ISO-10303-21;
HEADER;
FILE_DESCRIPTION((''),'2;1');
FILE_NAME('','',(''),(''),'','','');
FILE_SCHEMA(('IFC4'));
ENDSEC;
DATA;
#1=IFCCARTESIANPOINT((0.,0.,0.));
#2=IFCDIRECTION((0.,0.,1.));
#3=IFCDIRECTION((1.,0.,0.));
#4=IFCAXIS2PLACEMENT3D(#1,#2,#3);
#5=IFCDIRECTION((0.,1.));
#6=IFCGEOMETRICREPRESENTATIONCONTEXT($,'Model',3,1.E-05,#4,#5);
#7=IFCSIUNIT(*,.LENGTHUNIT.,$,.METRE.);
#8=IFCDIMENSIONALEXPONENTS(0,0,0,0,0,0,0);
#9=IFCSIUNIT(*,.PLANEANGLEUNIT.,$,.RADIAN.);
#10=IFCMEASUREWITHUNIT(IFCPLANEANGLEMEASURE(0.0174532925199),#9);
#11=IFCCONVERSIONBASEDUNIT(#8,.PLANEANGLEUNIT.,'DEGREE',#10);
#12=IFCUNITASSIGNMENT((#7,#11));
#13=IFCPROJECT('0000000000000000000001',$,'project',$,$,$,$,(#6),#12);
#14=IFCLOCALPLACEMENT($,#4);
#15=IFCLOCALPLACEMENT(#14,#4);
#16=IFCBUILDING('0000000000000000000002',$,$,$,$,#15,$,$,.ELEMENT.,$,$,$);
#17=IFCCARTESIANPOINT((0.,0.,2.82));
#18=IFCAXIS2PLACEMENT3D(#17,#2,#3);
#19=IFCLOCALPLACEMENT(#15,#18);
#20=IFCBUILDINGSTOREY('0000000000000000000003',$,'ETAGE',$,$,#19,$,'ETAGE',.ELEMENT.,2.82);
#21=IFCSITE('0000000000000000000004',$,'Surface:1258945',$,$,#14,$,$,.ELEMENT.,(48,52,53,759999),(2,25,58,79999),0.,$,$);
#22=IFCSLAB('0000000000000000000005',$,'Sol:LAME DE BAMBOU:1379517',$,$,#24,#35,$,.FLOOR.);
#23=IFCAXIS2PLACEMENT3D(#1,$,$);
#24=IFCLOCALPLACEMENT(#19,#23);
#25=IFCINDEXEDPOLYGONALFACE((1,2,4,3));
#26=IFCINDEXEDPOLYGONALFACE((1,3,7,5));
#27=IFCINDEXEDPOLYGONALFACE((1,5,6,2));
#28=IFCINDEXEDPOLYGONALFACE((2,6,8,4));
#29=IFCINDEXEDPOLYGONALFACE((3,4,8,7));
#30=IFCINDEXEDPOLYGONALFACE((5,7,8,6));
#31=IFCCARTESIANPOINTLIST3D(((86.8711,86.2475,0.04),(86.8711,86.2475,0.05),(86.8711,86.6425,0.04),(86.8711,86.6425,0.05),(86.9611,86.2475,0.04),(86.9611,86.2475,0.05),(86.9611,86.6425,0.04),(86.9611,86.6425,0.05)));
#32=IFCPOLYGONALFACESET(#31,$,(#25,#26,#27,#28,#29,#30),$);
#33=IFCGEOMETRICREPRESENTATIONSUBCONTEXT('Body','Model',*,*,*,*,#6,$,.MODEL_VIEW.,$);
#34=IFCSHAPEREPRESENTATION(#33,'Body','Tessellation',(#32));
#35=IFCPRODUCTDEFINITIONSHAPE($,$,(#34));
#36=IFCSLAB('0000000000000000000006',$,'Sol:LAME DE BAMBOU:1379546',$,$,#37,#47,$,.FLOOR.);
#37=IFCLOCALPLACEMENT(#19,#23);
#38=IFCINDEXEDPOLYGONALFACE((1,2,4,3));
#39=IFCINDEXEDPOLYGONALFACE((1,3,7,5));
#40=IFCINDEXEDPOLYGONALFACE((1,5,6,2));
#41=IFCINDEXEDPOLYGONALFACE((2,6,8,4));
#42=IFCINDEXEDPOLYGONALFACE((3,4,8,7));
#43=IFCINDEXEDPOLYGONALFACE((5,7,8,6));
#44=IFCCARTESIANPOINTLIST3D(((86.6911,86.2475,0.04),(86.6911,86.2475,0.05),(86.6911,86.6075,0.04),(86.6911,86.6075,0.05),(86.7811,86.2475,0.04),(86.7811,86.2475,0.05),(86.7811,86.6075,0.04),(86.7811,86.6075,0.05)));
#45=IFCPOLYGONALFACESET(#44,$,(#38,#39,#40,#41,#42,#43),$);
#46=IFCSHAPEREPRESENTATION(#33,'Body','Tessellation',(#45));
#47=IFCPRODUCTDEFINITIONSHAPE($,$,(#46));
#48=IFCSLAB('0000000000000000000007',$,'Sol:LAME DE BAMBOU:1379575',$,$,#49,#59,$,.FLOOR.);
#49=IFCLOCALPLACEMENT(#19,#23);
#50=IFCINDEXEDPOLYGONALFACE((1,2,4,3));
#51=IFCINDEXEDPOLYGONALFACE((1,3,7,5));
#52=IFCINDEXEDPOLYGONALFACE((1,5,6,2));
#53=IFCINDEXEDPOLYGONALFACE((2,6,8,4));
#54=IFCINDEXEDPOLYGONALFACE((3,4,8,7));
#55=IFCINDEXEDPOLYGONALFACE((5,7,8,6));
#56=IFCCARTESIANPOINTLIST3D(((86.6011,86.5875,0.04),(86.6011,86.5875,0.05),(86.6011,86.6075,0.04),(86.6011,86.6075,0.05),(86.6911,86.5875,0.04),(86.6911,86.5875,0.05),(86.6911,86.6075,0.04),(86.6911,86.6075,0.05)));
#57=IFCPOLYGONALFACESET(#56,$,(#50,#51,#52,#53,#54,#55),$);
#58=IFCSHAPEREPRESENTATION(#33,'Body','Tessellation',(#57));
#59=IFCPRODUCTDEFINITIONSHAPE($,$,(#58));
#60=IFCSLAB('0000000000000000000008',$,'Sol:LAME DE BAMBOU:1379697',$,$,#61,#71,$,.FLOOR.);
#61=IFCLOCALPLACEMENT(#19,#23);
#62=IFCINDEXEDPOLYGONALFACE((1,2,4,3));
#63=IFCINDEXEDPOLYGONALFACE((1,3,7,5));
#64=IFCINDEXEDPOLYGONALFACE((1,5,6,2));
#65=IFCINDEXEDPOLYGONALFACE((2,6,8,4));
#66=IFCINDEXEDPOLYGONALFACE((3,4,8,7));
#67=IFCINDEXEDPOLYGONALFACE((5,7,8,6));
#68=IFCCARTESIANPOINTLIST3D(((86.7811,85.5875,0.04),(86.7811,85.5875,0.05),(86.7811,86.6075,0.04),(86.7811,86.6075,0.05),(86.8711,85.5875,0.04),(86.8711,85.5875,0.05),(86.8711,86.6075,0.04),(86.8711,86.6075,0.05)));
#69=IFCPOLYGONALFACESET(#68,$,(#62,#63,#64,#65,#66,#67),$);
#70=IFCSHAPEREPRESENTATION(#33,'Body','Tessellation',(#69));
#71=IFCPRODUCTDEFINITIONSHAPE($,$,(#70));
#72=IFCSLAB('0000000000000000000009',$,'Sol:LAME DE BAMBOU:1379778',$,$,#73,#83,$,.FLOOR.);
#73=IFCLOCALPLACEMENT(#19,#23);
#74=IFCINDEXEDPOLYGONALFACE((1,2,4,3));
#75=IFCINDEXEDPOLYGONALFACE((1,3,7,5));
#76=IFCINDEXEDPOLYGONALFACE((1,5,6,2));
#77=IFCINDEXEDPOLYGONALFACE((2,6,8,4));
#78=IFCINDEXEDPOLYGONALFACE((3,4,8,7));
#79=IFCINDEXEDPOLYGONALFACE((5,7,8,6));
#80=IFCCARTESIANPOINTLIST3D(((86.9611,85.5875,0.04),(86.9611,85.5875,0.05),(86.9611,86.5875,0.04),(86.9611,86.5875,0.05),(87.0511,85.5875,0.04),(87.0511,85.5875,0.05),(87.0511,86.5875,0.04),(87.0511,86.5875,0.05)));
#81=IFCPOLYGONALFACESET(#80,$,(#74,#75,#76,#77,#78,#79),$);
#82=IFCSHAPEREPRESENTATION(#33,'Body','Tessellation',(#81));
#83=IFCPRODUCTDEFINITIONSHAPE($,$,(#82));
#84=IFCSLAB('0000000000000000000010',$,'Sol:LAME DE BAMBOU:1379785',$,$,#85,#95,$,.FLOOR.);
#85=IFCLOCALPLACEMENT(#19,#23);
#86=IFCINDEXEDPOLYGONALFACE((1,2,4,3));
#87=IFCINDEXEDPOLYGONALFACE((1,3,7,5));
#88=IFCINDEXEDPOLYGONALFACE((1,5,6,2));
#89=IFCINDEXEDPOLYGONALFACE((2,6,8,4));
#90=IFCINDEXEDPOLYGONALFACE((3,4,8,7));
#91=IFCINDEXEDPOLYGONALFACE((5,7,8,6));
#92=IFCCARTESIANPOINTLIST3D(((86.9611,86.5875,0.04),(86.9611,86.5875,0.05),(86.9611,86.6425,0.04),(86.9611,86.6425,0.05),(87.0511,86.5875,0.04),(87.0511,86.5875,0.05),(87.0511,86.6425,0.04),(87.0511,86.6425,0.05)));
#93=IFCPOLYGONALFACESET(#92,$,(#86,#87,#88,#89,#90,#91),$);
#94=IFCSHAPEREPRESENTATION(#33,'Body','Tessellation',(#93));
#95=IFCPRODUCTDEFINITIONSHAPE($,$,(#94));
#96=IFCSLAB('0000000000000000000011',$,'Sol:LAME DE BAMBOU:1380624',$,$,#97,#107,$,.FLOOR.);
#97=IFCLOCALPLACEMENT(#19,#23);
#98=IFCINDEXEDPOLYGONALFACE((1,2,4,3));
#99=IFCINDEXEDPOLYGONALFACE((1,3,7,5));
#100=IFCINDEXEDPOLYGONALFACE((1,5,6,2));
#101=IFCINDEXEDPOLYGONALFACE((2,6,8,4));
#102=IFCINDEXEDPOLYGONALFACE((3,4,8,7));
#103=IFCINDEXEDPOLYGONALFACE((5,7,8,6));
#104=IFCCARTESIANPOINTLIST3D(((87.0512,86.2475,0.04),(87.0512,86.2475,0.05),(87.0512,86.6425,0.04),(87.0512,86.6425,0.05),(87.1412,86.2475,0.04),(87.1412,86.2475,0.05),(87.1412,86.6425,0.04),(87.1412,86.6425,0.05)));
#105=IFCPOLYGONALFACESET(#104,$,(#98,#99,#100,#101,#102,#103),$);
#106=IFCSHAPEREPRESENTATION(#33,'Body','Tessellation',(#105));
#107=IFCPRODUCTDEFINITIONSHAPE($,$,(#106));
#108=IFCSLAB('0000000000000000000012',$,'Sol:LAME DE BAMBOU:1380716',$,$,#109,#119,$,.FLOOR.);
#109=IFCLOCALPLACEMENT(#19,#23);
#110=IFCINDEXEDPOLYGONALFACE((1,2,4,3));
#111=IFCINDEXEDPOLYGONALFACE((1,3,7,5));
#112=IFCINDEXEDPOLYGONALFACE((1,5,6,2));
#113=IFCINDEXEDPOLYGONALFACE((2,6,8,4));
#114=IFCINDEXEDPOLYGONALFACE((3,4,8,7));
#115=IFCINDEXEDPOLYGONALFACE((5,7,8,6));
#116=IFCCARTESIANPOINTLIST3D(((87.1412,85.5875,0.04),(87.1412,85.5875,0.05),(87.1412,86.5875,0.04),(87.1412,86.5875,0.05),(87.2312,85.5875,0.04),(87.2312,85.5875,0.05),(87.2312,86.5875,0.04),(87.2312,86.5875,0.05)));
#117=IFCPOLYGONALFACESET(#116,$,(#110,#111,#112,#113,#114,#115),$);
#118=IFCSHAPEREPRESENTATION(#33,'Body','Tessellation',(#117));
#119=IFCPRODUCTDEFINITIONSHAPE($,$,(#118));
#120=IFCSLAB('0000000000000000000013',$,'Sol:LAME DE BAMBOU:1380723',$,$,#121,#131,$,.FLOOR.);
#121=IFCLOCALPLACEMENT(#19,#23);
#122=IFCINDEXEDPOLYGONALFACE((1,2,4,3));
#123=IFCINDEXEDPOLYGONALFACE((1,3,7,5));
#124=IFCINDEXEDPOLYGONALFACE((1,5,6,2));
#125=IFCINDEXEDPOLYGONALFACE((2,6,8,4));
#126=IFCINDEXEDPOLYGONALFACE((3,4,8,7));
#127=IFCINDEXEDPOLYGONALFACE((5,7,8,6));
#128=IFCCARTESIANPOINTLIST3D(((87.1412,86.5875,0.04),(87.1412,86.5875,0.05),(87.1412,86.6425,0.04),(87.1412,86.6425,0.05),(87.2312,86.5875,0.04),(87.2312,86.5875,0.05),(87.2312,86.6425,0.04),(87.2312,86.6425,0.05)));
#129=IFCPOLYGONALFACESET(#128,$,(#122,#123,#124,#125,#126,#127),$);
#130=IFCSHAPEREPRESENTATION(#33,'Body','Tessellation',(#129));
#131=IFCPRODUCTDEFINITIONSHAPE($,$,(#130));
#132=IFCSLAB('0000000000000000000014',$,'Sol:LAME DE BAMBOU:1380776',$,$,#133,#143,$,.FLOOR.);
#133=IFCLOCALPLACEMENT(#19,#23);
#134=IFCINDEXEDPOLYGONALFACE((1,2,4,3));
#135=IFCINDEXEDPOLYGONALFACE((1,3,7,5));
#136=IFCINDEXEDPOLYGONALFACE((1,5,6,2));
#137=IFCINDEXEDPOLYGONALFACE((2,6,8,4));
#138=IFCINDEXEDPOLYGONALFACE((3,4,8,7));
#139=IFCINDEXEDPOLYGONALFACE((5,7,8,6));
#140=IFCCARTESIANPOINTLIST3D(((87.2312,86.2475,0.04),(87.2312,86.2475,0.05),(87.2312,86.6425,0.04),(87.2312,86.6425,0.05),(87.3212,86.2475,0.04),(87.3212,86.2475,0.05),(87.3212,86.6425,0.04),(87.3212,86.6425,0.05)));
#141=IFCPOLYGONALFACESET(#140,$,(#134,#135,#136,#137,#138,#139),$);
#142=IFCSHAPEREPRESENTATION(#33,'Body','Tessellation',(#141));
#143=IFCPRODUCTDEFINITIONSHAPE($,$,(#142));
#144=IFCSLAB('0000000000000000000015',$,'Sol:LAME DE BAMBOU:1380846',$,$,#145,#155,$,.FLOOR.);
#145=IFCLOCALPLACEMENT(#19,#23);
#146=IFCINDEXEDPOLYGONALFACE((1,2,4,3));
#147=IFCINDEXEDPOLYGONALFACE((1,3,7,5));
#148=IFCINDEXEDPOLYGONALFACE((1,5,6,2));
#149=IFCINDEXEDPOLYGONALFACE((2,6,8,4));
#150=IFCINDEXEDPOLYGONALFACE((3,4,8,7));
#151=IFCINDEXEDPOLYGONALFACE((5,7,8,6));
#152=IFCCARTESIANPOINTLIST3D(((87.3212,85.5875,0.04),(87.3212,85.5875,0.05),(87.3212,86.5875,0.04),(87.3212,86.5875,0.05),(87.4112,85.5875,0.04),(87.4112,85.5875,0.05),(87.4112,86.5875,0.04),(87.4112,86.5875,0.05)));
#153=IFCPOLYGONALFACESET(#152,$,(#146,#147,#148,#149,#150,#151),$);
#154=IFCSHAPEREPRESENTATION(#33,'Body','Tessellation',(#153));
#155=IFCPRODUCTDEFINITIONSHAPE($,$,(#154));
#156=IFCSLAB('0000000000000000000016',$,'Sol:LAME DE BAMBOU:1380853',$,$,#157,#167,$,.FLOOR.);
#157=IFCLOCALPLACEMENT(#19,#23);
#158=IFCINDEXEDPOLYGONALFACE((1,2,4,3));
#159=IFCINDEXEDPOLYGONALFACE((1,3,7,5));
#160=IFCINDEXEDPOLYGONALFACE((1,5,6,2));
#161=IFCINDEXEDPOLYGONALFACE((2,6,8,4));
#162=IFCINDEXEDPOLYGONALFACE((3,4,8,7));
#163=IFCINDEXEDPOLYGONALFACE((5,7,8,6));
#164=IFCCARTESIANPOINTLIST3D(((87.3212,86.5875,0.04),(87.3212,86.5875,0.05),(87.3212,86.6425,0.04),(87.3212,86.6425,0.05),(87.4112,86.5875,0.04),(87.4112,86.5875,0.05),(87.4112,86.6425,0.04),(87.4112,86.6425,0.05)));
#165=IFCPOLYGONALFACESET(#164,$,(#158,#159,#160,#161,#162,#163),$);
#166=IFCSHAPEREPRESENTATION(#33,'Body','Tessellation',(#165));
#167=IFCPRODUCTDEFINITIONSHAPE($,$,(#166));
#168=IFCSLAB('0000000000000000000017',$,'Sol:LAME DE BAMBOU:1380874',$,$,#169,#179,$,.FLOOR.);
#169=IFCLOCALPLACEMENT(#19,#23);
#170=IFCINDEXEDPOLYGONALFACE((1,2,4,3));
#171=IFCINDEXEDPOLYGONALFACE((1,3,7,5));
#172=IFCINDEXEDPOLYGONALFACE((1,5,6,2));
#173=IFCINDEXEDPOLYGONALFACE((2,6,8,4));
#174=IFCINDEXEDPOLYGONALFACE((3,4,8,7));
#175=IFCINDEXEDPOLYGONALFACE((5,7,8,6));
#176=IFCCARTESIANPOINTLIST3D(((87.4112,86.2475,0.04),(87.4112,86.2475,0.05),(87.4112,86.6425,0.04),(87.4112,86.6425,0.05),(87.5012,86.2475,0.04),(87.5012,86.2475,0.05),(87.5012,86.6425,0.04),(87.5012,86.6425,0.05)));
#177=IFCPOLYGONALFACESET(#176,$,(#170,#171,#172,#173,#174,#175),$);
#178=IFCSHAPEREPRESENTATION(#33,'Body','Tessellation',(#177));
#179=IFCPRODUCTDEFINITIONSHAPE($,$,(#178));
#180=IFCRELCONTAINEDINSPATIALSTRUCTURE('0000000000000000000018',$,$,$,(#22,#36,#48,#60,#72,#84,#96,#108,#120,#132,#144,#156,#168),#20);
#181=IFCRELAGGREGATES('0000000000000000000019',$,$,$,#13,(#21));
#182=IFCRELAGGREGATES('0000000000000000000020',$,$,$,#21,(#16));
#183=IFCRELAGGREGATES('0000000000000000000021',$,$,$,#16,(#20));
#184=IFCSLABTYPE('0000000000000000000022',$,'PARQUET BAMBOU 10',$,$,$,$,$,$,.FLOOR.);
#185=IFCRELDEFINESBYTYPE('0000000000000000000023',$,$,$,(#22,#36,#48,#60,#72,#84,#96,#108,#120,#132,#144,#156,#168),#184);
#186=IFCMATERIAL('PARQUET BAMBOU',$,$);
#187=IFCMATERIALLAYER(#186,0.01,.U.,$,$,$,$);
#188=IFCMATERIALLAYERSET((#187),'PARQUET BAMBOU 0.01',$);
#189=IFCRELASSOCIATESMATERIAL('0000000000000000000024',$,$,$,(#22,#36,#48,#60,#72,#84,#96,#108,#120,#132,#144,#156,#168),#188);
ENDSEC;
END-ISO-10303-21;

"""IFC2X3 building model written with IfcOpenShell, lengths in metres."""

from ifc_helpers import new_model, entity, si_unit, converted_unit, direction, frame, origin_with_axes, place, context, subcontext, project, spatial, polyline, outline, extrude, material, layer, layer_set, layer_usage, type_object, element, save


model = new_model("IFC2X3")

# Units and contexts
model_context = context("Model", 3, precision=1e-05, world=origin_with_axes(), true_north=direction((0.0, 1.0)))
body_context = subcontext(model_context, "Body", "Model", "MODEL_VIEW")
ifc_project = project(units=[si_unit("LENGTHUNIT", "METRE"), converted_unit("PLANEANGLEUNIT", "DEGREE", entity("IfcPlaneAngleMeasure", 0.0174532925199), si_unit("PLANEANGLEUNIT", "RADIAN"), dimensions=[0, 0, 0, 0, 0, 0, 0])], contexts=[model_context])

# Site, building, storey
site_placement = place(None, origin_with_axes())
site = spatial("IfcSite", under=ifc_project, at=site_placement, Name="Surface:1258945", CompositionType="ELEMENT", RefLatitude=(48, 52, 53, 759999), RefLongitude=(2, 25, 58, 79999), RefElevation=0.0)
building_placement = place(site_placement, origin_with_axes())
building = spatial("IfcBuilding", under=site, at=building_placement, CompositionType="ELEMENT")
storey_placement = place(building_placement, frame((0.0, 0.0, 2.82), z_axis=(0.0, 0.0, 1.0), x_axis=(1.0, 0.0, 0.0)))
storey = spatial("IfcBuildingStorey", under=building, at=storey_placement, Name="ETAGE", LongName="ETAGE", CompositionType="ELEMENT", Elevation=2.82)

# Slabs
ifc_material_1 = material(Name="PARQUET BAMBOU")
ifc_layer_1 = layer(ifc_material_1, 0.01, ventilated="UNKNOWN")
ifc_layer_set_1 = layer_set([ifc_layer_1], Name="PARQUET BAMBOU 0.01")
ifc_layer_usage_1 = layer_usage(ifc_layer_set_1, "AXIS3", "NEGATIVE", 0.01)
slab_type = type_object("IfcSlabType", Name="PARQUET BAMBOU 10", PredefinedType="FLOOR")
slab_1_placement = place(storey_placement, frame((86.8711, 86.6425, 0.05), z_axis=(0.0, 0.0, 1.0), x_axis=(1.0, 0.0, 0.0)))
element("IfcSlab", 1, at=slab_1_placement, inside=storey, type_object=slab_type, material=ifc_layer_usage_1, Name="Sol:LAME DE BAMBOU:1379517", PredefinedType="FLOOR", context=body_context, shape_type="SweptSolid", body=[
    extrude(outline(polyline([(0.0, 0.0), (0.0, -0.395), (0.09, -0.395), (0.09, 0.0), (0.0, 0.0)])), frame((0.0, 0.0, -0.01), z_axis=(0.0, 0.0, 1.0), x_axis=(1.0, 0.0, 0.0)), (0.0, 0.0, 1.0), 0.01),
])
ifc_layer_usage_2 = layer_usage(ifc_layer_set_1, "AXIS3", "NEGATIVE", 0.01)
slab_2_placement = place(storey_placement, frame((86.6911, 86.6075, 0.05), z_axis=(0.0, 0.0, 1.0), x_axis=(1.0, 0.0, 0.0)))
element("IfcSlab", 2, at=slab_2_placement, inside=storey, type_object=slab_type, material=ifc_layer_usage_2, Name="Sol:LAME DE BAMBOU:1379546", PredefinedType="FLOOR", context=body_context, shape_type="SweptSolid", body=[
    extrude(outline(polyline([(0.0, 0.0), (0.0, -0.36), (0.09, -0.36), (0.09, 0.0), (0.0, 0.0)])), frame((0.0, 0.0, -0.01), z_axis=(0.0, 0.0, 1.0), x_axis=(1.0, 0.0, 0.0)), (0.0, 0.0, 1.0), 0.01),
])
ifc_layer_usage_3 = layer_usage(ifc_layer_set_1, "AXIS3", "NEGATIVE", 0.01)
slab_3_placement = place(storey_placement, frame((86.6011, 86.6075, 0.05), z_axis=(0.0, 0.0, 1.0), x_axis=(1.0, 0.0, 0.0)))
element("IfcSlab", 3, at=slab_3_placement, inside=storey, type_object=slab_type, material=ifc_layer_usage_3, Name="Sol:LAME DE BAMBOU:1379575", PredefinedType="FLOOR", context=body_context, shape_type="SweptSolid", body=[
    extrude(outline(polyline([(0.0, 0.0), (0.0, -0.02), (0.09, -0.02), (0.09, 0.0), (0.0, 0.0)])), frame((0.0, 0.0, -0.01), z_axis=(0.0, 0.0, 1.0), x_axis=(1.0, 0.0, 0.0)), (0.0, 0.0, 1.0), 0.01),
])
ifc_layer_usage_4 = layer_usage(ifc_layer_set_1, "AXIS3", "NEGATIVE", 0.01)
slab_4_placement = place(storey_placement, frame((86.7811, 86.6075, 0.05), z_axis=(0.0, 0.0, 1.0), x_axis=(1.0, 0.0, 0.0)))
element("IfcSlab", 4, at=slab_4_placement, inside=storey, type_object=slab_type, material=ifc_layer_usage_4, Name="Sol:LAME DE BAMBOU:1379697", PredefinedType="FLOOR", context=body_context, shape_type="SweptSolid", body=[
    extrude(outline(polyline([(0.0, 0.0), (0.0, -1.02), (0.09, -1.02), (0.09, 0.0), (0.0, 0.0)])), frame((0.0, 0.0, -0.01), z_axis=(0.0, 0.0, 1.0), x_axis=(1.0, 0.0, 0.0)), (0.0, 0.0, 1.0), 0.01),
])
ifc_layer_usage_5 = layer_usage(ifc_layer_set_1, "AXIS3", "NEGATIVE", 0.01)
slab_5_placement = place(storey_placement, frame((86.9611, 86.5875, 0.05), z_axis=(0.0, 0.0, 1.0), x_axis=(1.0, 0.0, 0.0)))
element("IfcSlab", 5, at=slab_5_placement, inside=storey, type_object=slab_type, material=ifc_layer_usage_5, Name="Sol:LAME DE BAMBOU:1379778", PredefinedType="FLOOR", context=body_context, shape_type="SweptSolid", body=[
    extrude(outline(polyline([(0.0, 0.0), (0.0, -1.0), (0.09, -1.0), (0.09, 0.0), (0.0, 0.0)])), frame((0.0, 0.0, -0.01), z_axis=(0.0, 0.0, 1.0), x_axis=(1.0, 0.0, 0.0)), (0.0, 0.0, 1.0), 0.01),
])
ifc_layer_usage_6 = layer_usage(ifc_layer_set_1, "AXIS3", "NEGATIVE", 0.01)
slab_6_placement = place(storey_placement, frame((86.9611, 86.6425, 0.05), z_axis=(0.0, 0.0, 1.0), x_axis=(1.0, 0.0, 0.0)))
element("IfcSlab", 6, at=slab_6_placement, inside=storey, type_object=slab_type, material=ifc_layer_usage_6, Name="Sol:LAME DE BAMBOU:1379785", PredefinedType="FLOOR", context=body_context, shape_type="SweptSolid", body=[
    extrude(outline(polyline([(0.0, 0.0), (0.0, -0.055), (0.09, -0.055), (0.09, 0.0), (0.0, 0.0)])), frame((0.0, 0.0, -0.01), z_axis=(0.0, 0.0, 1.0), x_axis=(1.0, 0.0, 0.0)), (0.0, 0.0, 1.0), 0.01),
])
ifc_layer_usage_7 = layer_usage(ifc_layer_set_1, "AXIS3", "NEGATIVE", 0.01)
slab_7_placement = place(storey_placement, frame((87.0512, 86.6425, 0.05), z_axis=(0.0, 0.0, 1.0), x_axis=(1.0, 0.0, 0.0)))
element("IfcSlab", 7, at=slab_7_placement, inside=storey, type_object=slab_type, material=ifc_layer_usage_7, Name="Sol:LAME DE BAMBOU:1380624", PredefinedType="FLOOR", context=body_context, shape_type="SweptSolid", body=[
    extrude(outline(polyline([(0.0, 0.0), (0.0, -0.395), (0.09, -0.395), (0.09, 0.0), (0.0, 0.0)])), frame((0.0, 0.0, -0.01), z_axis=(0.0, 0.0, 1.0), x_axis=(1.0, 0.0, 0.0)), (0.0, 0.0, 1.0), 0.01),
])
ifc_layer_usage_8 = layer_usage(ifc_layer_set_1, "AXIS3", "NEGATIVE", 0.01)
slab_8_placement = place(storey_placement, frame((87.1412, 86.5875, 0.05), z_axis=(0.0, 0.0, 1.0), x_axis=(1.0, 0.0, 0.0)))
element("IfcSlab", 8, at=slab_8_placement, inside=storey, type_object=slab_type, material=ifc_layer_usage_8, Name="Sol:LAME DE BAMBOU:1380716", PredefinedType="FLOOR", context=body_context, shape_type="SweptSolid", body=[
    extrude(outline(polyline([(0.0, 0.0), (0.0, -1.0), (0.09, -1.0), (0.09, 0.0), (0.0, 0.0)])), frame((0.0, 0.0, -0.01), z_axis=(0.0, 0.0, 1.0), x_axis=(1.0, 0.0, 0.0)), (0.0, 0.0, 1.0), 0.01),
])
ifc_layer_usage_9 = layer_usage(ifc_layer_set_1, "AXIS3", "NEGATIVE", 0.01)
slab_9_placement = place(storey_placement, frame((87.1412, 86.6425, 0.05), z_axis=(0.0, 0.0, 1.0), x_axis=(1.0, 0.0, 0.0)))
element("IfcSlab", 9, at=slab_9_placement, inside=storey, type_object=slab_type, material=ifc_layer_usage_9, Name="Sol:LAME DE BAMBOU:1380723", PredefinedType="FLOOR", context=body_context, shape_type="SweptSolid", body=[
    extrude(outline(polyline([(0.0, 0.0), (0.0, -0.055), (0.09, -0.055), (0.09, 0.0), (0.0, 0.0)])), frame((0.0, 0.0, -0.01), z_axis=(0.0, 0.0, 1.0), x_axis=(1.0, 0.0, 0.0)), (0.0, 0.0, 1.0), 0.01),
])
ifc_layer_usage_10 = layer_usage(ifc_layer_set_1, "AXIS3", "NEGATIVE", 0.01)
slab_10_placement = place(storey_placement, frame((87.2312, 86.6425, 0.05), z_axis=(0.0, 0.0, 1.0), x_axis=(1.0, 0.0, 0.0)))
element("IfcSlab", 10, at=slab_10_placement, inside=storey, type_object=slab_type, material=ifc_layer_usage_10, Name="Sol:LAME DE BAMBOU:1380776", PredefinedType="FLOOR", context=body_context, shape_type="SweptSolid", body=[
    extrude(outline(polyline([(0.0, 0.0), (0.0, -0.395), (0.09, -0.395), (0.09, 0.0), (0.0, 0.0)])), frame((0.0, 0.0, -0.01), z_axis=(0.0, 0.0, 1.0), x_axis=(1.0, 0.0, 0.0)), (0.0, 0.0, 1.0), 0.01),
])
ifc_layer_usage_11 = layer_usage(ifc_layer_set_1, "AXIS3", "NEGATIVE", 0.01)
slab_11_placement = place(storey_placement, frame((87.3212, 86.5875, 0.05), z_axis=(0.0, 0.0, 1.0), x_axis=(1.0, 0.0, 0.0)))
element("IfcSlab", 11, at=slab_11_placement, inside=storey, type_object=slab_type, material=ifc_layer_usage_11, Name="Sol:LAME DE BAMBOU:1380846", PredefinedType="FLOOR", context=body_context, shape_type="SweptSolid", body=[
    extrude(outline(polyline([(0.0, 0.0), (0.0, -1.0), (0.09, -1.0), (0.09, 0.0), (0.0, 0.0)])), frame((0.0, 0.0, -0.01), z_axis=(0.0, 0.0, 1.0), x_axis=(1.0, 0.0, 0.0)), (0.0, 0.0, 1.0), 0.01),
])
ifc_layer_usage_12 = layer_usage(ifc_layer_set_1, "AXIS3", "NEGATIVE", 0.01)
slab_12_placement = place(storey_placement, frame((87.3212, 86.6425, 0.05), z_axis=(0.0, 0.0, 1.0), x_axis=(1.0, 0.0, 0.0)))
element("IfcSlab", 12, at=slab_12_placement, inside=storey, type_object=slab_type, material=ifc_layer_usage_12, Name="Sol:LAME DE BAMBOU:1380853", PredefinedType="FLOOR", context=body_context, shape_type="SweptSolid", body=[
    extrude(outline(polyline([(0.0, 0.0), (0.0, -0.055), (0.09, -0.055), (0.09, 0.0), (0.0, 0.0)])), frame((0.0, 0.0, -0.01), z_axis=(0.0, 0.0, 1.0), x_axis=(1.0, 0.0, 0.0)), (0.0, 0.0, 1.0), 0.01),
])
ifc_layer_usage_13 = layer_usage(ifc_layer_set_1, "AXIS3", "NEGATIVE", 0.01)
slab_13_placement = place(storey_placement, frame((87.4112, 86.6425, 0.05), z_axis=(0.0, 0.0, 1.0), x_axis=(1.0, 0.0, 0.0)))
element("IfcSlab", 13, at=slab_13_placement, inside=storey, type_object=slab_type, material=ifc_layer_usage_13, Name="Sol:LAME DE BAMBOU:1380874", PredefinedType="FLOOR", context=body_context, shape_type="SweptSolid", body=[
    extrude(outline(polyline([(0.0, 0.0), (0.0, -0.395), (0.09, -0.395), (0.09, 0.0), (0.0, 0.0)])), frame((0.0, 0.0, -0.01), z_axis=(0.0, 0.0, 1.0), x_axis=(1.0, 0.0, 0.0)), (0.0, 0.0, 1.0), 0.01),
])

save(model, "model.ifc")
